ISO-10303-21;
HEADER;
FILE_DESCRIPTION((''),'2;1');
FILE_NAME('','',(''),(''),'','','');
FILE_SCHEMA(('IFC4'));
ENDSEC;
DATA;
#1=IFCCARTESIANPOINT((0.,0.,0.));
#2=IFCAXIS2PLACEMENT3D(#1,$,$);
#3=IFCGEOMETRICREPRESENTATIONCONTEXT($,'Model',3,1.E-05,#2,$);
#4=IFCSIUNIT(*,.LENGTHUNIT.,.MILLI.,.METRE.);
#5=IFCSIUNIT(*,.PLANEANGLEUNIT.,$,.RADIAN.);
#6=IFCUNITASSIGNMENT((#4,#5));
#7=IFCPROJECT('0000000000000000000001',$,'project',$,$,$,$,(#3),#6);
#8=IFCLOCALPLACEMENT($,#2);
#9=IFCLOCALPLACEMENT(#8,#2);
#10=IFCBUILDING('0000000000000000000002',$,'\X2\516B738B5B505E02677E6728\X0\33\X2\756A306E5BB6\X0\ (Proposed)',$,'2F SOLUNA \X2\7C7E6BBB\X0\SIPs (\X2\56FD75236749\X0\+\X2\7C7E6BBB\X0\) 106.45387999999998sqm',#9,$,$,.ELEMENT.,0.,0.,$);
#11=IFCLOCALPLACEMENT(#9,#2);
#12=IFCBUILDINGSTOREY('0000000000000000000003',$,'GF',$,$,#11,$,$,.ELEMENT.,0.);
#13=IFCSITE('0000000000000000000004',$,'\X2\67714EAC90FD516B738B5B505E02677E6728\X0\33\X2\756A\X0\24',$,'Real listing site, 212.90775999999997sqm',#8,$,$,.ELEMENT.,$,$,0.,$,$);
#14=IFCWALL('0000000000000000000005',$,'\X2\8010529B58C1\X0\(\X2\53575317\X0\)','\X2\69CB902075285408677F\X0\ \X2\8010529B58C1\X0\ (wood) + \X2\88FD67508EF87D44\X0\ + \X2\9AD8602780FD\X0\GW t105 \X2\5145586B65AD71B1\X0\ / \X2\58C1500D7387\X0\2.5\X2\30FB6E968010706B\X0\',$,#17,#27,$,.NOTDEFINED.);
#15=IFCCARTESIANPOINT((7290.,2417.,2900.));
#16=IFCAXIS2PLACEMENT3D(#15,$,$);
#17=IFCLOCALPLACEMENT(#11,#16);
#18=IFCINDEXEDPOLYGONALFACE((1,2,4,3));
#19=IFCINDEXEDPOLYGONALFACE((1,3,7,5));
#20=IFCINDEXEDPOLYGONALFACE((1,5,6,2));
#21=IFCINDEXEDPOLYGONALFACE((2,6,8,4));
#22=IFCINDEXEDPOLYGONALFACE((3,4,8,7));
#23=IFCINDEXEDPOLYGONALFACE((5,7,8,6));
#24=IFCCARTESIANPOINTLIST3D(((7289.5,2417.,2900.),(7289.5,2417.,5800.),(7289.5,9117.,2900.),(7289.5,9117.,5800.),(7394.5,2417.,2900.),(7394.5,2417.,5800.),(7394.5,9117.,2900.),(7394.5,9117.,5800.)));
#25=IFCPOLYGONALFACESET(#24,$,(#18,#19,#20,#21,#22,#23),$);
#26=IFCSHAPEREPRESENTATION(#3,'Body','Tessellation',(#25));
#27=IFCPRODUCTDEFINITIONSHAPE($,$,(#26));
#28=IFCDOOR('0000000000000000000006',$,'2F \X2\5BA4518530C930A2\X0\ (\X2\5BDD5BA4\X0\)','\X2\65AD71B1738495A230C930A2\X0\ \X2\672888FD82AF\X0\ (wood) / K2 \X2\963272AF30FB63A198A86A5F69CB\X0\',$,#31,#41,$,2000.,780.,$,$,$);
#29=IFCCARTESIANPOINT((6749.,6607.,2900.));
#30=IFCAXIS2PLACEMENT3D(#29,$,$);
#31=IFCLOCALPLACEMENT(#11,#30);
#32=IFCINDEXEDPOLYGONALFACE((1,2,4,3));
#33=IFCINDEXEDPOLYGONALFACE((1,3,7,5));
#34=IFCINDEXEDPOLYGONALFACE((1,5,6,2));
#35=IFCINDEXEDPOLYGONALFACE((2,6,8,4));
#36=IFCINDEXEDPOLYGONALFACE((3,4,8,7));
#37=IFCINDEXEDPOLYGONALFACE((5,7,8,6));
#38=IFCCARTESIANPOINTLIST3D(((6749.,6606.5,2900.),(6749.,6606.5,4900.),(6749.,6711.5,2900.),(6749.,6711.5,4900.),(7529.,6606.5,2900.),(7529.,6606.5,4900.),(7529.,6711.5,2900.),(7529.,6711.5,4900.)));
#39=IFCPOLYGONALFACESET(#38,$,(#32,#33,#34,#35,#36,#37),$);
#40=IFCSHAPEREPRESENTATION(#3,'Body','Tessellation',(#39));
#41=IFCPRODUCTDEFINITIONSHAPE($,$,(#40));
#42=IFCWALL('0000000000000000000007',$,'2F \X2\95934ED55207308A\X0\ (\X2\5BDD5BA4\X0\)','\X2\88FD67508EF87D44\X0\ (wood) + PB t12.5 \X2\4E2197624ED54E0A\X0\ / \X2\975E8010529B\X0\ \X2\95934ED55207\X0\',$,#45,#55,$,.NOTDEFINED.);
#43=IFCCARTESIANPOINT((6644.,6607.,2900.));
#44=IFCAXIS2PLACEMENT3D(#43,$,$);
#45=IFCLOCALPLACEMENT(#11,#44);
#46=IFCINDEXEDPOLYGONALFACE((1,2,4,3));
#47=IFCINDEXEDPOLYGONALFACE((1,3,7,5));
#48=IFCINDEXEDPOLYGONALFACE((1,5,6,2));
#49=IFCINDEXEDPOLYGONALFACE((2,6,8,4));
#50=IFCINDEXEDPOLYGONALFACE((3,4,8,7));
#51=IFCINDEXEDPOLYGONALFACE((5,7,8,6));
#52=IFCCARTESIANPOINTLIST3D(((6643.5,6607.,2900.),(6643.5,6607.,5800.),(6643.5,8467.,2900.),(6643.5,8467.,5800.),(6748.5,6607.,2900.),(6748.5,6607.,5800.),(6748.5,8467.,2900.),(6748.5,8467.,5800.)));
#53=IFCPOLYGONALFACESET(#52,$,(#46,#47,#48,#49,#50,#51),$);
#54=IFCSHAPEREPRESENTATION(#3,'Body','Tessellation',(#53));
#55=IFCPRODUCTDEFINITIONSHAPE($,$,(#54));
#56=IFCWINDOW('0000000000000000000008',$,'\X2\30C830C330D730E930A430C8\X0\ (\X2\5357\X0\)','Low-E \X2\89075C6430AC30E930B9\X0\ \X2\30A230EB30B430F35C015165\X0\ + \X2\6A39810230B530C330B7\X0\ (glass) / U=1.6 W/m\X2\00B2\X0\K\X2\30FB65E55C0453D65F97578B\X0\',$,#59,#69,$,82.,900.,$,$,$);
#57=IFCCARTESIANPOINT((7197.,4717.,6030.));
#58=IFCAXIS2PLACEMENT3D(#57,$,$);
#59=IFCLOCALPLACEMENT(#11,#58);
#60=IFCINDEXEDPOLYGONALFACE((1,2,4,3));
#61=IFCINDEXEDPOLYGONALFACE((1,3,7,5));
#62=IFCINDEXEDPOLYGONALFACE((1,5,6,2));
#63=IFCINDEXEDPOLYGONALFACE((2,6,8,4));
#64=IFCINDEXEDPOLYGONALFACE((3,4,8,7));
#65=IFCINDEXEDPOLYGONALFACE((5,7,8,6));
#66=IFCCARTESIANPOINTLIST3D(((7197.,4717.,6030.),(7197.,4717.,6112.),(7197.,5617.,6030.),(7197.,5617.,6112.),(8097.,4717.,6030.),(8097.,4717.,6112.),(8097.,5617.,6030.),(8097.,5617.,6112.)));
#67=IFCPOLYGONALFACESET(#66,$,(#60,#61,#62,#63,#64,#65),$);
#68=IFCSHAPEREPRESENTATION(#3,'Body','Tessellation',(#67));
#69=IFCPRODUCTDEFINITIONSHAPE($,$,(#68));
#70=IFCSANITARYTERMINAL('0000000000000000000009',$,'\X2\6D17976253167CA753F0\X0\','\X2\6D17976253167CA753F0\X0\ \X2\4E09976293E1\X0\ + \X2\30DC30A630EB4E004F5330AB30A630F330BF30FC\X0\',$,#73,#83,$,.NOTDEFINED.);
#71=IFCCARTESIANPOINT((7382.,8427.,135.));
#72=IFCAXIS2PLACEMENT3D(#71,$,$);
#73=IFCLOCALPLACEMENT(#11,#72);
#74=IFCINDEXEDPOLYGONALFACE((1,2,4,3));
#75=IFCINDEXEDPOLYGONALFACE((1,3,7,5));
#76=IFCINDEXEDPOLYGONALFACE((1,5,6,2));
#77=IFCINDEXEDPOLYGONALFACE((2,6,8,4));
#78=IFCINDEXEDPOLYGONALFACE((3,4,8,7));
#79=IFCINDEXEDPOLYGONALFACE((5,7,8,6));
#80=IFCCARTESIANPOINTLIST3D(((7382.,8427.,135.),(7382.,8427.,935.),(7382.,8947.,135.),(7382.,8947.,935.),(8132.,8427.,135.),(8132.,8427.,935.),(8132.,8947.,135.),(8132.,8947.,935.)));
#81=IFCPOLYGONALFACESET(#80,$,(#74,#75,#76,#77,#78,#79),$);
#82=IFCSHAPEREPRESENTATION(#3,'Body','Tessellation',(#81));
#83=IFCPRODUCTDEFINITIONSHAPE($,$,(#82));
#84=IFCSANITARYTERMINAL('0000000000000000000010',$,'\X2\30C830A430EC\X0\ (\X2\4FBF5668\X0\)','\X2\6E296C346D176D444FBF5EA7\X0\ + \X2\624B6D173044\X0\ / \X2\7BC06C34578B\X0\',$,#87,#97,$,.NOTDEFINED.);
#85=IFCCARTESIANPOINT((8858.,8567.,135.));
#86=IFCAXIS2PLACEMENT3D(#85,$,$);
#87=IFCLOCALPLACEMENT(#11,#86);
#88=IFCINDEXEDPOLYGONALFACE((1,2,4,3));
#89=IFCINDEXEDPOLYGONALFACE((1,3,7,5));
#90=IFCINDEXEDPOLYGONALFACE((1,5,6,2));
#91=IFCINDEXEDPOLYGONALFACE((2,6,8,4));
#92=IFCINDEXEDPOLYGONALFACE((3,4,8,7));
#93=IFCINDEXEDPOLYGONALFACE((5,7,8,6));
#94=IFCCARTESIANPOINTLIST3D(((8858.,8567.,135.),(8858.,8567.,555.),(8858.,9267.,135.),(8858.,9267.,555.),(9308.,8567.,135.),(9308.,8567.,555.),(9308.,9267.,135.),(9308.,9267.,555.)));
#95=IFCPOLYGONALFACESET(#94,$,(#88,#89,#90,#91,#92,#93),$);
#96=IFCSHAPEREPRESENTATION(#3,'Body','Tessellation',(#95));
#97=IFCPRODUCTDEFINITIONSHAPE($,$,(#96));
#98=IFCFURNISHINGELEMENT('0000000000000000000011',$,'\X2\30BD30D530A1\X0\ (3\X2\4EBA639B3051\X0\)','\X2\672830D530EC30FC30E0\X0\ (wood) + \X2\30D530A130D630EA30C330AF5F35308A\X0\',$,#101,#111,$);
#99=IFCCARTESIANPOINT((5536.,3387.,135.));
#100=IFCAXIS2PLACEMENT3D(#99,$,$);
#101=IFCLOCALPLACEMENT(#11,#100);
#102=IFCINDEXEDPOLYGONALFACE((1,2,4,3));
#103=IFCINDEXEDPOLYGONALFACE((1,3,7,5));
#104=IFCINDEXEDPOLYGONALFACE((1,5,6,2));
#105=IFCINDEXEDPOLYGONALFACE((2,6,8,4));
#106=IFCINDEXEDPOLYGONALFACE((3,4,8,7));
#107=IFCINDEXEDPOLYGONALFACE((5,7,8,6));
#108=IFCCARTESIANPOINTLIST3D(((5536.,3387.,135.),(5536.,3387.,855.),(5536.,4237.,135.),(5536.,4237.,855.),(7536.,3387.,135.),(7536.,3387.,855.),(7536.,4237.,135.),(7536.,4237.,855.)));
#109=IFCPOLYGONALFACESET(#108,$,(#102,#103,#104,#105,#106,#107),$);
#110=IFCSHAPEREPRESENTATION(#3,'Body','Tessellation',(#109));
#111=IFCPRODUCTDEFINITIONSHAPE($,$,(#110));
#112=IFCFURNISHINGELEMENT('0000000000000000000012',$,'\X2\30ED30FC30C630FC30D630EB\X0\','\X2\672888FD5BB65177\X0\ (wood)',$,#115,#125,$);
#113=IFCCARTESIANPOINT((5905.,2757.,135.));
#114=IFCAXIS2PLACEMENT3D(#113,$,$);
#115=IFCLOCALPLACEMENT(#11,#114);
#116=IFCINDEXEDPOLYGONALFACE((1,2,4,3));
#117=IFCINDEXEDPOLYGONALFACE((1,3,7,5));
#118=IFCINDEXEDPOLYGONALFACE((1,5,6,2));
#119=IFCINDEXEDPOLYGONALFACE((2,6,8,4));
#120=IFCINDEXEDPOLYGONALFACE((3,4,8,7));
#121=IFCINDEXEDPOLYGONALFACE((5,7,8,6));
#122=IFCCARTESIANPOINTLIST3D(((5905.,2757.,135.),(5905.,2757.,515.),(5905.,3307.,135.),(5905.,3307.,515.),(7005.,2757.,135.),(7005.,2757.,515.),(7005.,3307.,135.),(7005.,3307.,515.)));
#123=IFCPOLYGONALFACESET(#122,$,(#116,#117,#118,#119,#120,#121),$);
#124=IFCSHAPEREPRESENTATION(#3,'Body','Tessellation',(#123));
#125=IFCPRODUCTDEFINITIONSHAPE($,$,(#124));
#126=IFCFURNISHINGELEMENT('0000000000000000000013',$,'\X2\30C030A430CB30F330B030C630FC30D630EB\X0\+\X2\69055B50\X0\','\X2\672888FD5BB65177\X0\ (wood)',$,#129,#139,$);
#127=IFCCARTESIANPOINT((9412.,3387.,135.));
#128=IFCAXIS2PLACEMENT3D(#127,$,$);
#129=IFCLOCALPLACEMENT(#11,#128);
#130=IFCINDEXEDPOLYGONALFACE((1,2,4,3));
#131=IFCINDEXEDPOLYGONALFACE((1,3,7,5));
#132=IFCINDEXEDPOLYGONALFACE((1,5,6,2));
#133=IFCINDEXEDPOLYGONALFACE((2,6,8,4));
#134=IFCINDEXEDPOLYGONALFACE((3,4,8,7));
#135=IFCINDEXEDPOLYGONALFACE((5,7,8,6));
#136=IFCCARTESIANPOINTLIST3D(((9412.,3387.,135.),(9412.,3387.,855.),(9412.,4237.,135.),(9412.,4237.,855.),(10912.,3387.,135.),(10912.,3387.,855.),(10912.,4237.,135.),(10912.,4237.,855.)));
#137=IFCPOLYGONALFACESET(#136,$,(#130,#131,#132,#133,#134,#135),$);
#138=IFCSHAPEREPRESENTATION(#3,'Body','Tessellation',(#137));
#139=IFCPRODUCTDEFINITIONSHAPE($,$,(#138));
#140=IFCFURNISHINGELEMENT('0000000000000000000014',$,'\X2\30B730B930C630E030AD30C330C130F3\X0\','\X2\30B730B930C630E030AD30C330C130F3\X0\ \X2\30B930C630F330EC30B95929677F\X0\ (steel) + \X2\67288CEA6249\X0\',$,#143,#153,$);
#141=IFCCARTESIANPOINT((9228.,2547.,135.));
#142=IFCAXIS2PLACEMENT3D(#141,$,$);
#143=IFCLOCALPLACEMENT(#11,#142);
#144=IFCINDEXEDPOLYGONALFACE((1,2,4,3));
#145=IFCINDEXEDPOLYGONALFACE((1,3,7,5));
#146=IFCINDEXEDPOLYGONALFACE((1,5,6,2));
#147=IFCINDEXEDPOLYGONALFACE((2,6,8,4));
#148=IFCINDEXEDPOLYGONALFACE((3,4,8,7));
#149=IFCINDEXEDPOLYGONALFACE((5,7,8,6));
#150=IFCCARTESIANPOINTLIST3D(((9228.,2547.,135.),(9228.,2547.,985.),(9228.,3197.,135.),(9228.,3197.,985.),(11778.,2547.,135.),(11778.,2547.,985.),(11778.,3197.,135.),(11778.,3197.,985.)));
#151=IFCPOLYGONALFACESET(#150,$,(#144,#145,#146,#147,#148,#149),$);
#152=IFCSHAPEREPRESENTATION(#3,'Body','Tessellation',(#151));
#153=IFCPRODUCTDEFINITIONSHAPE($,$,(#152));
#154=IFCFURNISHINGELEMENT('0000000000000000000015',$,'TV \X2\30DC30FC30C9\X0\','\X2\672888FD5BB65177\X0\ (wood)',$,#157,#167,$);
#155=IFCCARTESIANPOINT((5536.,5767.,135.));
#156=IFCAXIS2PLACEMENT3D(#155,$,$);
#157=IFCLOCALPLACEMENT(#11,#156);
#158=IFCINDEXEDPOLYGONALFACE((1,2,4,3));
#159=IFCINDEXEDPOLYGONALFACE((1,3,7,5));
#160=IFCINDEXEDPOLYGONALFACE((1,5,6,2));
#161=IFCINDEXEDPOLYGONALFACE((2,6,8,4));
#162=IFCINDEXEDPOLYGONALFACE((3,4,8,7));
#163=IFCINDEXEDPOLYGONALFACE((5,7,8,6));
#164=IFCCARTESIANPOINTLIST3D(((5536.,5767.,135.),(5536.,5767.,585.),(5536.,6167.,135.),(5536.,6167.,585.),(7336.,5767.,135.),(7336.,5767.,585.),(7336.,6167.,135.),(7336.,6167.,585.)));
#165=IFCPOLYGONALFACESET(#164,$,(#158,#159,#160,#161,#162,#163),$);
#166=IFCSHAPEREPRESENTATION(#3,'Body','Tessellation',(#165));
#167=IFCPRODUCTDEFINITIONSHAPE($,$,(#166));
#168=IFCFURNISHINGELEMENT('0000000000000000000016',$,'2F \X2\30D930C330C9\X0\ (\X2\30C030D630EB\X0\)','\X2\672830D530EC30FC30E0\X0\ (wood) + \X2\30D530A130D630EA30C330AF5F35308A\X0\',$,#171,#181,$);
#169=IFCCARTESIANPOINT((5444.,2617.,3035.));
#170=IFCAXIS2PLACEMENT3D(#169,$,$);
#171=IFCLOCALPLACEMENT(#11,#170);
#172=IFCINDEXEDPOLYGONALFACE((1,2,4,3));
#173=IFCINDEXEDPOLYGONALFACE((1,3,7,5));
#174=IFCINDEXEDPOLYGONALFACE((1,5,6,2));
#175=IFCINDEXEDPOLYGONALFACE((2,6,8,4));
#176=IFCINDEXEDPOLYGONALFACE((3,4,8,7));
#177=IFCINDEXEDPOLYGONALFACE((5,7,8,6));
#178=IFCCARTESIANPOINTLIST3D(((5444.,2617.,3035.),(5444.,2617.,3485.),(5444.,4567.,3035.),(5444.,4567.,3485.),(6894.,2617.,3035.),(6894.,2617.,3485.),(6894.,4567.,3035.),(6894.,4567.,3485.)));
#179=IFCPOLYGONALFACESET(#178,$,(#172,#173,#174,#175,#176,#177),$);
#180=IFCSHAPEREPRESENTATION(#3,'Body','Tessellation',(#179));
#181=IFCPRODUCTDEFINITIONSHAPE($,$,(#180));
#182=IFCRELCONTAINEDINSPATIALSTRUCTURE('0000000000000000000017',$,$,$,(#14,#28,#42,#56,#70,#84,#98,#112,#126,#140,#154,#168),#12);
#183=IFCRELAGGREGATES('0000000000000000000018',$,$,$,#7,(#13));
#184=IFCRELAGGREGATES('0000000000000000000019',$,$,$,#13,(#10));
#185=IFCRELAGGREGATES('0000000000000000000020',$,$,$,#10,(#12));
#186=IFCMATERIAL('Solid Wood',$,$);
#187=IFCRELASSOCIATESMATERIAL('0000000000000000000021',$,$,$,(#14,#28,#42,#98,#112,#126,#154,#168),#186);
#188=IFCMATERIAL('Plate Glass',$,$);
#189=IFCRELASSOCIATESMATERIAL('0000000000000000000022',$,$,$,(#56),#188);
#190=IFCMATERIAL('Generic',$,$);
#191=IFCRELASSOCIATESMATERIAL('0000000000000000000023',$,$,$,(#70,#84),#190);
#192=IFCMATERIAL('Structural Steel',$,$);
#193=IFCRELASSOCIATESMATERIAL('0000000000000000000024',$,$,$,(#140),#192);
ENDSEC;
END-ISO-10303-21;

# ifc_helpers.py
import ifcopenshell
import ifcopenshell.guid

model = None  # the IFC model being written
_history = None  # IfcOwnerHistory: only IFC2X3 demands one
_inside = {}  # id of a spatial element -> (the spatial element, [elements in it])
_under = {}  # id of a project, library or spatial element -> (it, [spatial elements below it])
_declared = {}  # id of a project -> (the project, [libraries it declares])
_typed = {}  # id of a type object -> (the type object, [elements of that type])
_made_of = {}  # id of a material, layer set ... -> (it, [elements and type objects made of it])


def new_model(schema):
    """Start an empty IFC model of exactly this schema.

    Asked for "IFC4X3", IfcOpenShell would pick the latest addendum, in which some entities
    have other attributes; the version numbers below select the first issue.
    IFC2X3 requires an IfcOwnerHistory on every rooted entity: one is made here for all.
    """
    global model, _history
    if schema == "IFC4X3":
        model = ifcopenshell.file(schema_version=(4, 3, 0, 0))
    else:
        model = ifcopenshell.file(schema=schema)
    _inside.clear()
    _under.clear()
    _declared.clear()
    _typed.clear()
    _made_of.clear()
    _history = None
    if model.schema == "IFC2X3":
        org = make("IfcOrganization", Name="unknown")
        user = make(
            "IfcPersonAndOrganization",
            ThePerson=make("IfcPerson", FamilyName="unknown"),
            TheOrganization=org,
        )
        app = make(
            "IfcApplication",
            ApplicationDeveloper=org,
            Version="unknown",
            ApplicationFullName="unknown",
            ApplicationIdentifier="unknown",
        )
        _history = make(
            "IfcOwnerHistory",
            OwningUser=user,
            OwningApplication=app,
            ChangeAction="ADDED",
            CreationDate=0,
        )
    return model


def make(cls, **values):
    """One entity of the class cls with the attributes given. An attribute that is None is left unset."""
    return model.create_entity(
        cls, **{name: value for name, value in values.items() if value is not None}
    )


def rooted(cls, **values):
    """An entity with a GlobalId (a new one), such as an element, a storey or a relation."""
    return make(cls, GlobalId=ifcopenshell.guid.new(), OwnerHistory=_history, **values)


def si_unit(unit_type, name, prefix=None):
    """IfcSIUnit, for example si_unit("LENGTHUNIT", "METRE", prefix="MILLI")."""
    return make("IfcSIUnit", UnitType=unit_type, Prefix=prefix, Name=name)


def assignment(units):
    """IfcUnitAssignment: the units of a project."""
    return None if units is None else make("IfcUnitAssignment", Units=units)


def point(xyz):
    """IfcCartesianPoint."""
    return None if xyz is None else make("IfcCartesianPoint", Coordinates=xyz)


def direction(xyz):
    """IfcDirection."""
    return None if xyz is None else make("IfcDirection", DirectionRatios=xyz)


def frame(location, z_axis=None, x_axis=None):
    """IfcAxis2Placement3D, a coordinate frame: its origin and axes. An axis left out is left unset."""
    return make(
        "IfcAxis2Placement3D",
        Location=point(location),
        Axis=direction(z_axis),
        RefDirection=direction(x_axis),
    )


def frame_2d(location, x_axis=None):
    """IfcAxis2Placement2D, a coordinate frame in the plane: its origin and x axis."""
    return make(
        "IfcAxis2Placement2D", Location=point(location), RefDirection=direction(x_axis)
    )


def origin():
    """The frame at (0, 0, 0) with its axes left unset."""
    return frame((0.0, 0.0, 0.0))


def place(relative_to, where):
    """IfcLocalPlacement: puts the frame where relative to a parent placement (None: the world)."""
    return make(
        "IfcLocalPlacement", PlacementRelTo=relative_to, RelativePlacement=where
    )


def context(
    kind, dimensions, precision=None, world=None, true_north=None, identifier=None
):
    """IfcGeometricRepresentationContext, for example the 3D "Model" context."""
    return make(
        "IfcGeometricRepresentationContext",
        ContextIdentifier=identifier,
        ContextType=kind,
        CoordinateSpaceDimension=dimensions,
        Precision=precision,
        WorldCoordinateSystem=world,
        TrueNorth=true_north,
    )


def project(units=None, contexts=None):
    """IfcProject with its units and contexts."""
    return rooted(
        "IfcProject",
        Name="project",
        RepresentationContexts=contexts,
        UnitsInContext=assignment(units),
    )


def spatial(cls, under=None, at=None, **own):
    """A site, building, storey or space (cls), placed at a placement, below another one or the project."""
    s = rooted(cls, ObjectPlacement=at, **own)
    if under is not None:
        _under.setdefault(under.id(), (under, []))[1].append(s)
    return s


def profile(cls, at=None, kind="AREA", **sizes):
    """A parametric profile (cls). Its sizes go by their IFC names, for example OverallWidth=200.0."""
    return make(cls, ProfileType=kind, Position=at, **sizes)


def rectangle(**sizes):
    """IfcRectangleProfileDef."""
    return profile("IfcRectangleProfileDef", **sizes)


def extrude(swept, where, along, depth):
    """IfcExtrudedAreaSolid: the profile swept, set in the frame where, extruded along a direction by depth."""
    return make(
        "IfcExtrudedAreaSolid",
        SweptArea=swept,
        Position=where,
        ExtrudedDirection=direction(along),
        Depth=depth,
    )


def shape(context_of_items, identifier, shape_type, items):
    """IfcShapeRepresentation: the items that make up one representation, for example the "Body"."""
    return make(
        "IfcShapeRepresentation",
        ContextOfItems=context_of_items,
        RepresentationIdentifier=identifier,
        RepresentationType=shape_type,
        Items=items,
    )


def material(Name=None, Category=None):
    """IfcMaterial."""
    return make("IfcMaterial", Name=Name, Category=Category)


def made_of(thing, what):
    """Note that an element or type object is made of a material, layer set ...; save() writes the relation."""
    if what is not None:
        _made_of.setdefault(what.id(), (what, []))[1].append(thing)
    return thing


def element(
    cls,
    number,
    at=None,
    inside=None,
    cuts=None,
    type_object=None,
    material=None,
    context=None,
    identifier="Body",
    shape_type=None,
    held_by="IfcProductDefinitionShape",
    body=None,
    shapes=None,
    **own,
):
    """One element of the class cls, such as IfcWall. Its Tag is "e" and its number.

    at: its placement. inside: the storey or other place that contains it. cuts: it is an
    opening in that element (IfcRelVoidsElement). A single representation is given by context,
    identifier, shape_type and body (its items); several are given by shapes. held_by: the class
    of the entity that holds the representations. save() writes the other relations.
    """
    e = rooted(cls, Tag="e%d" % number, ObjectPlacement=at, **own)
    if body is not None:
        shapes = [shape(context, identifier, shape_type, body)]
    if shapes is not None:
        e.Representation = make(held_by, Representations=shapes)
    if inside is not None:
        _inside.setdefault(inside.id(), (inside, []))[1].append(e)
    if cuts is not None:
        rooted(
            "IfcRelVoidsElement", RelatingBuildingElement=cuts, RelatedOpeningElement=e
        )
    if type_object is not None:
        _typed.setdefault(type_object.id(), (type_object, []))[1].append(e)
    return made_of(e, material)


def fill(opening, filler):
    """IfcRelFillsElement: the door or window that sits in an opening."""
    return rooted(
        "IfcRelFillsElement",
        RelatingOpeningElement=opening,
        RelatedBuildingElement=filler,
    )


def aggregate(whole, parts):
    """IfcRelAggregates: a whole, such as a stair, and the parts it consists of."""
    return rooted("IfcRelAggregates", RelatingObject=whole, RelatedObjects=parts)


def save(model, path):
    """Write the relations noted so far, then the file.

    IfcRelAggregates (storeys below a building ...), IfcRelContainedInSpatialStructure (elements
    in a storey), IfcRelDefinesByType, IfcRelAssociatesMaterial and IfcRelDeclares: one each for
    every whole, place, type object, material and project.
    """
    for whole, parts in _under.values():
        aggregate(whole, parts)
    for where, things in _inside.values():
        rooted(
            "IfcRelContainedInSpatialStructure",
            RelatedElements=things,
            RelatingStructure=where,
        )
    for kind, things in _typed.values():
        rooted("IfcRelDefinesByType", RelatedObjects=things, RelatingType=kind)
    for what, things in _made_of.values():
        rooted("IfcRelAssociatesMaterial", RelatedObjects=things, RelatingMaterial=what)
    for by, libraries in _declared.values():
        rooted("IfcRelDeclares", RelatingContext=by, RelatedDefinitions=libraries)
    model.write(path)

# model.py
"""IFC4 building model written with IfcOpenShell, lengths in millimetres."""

from ifc_helpers import new_model, si_unit, frame, frame_2d, origin, place, context, project, spatial, rectangle, extrude, material, element, fill, save


model = new_model("IFC4")

# Units and contexts
model_context = context("Model", 3, precision=1e-05, world=origin())
ifc_project = project(units=[si_unit("LENGTHUNIT", "METRE", prefix="MILLI"), si_unit("PLANEANGLEUNIT", "RADIAN")], contexts=[model_context])

# Site, building, storey
site_placement = place(None, origin())
site = spatial("IfcSite", under=ifc_project, at=site_placement, Name="東京都八王子市松木33番24", ObjectType="Real listing site, 212.90775999999997sqm", CompositionType="ELEMENT", RefElevation=0.0)
building_placement = place(site_placement, origin())
building = spatial("IfcBuilding", under=site, at=building_placement, Name="八王子市松木33番の家 (Proposed)", ObjectType="2F SOLUNA 籾殻SIPs (国産杉+籾殻) 106.45387999999998sqm", CompositionType="ELEMENT", ElevationOfRefHeight=0.0, ElevationOfTerrain=0.0)
storey_placement = place(building_placement, origin())
storey = spatial("IfcBuildingStorey", under=building, at=storey_placement, Name="GF", CompositionType="ELEMENT", Elevation=0.0)

# Shared definitions
ifc_material_1 = material(Name="Solid Wood")

# Wall, opening, door
wall_1_placement = place(storey_placement, frame((7290.0, 2417.0, 2900.0)))
wall_1 = element("IfcWall", 1, at=wall_1_placement, inside=storey, material=ifc_material_1, Name="耐力壁(南北)", Description="構造用合板 耐力壁 (wood) + 製材軸組 + 高性能GW t105 充填断熱 / 壁倍率2.5・準耐火", PredefinedType="NOTDEFINED", context=model_context, shape_type="SweptSolid", body=[
    extrude(rectangle(XDim=105.0, YDim=6700.0, at=frame_2d((52.0, 3350.0))), frame((7290.0, 2417.0, 2900.0)), (0.0, 0.0, 1.0), 2900.0),
])
opening_1_placement = place(storey_placement, frame((6749.0, 6607.0, 2900.0)))
opening_1 = element("IfcOpeningElement", 2, at=opening_1_placement, cuts=wall_1, PredefinedType="NOTDEFINED", context=model_context, shape_type="SweptSolid", body=[
    extrude(rectangle(XDim=780.0, YDim=105.0, at=frame_2d((390.0, 52.0))), frame((6749.0, 6607.0, 2900.0)), (0.0, 0.0, 1.0), 2000.0),
])
door_1_placement = place(storey_placement, frame((6749.0, 6607.0, 2900.0)))
door_1 = element("IfcDoor", 3, at=door_1_placement, inside=storey, material=ifc_material_1, Name="2F 室内ドア (寝室)", Description="断熱玄関ドア 木製芯 (wood) / K2 防犯・採風機構", OverallHeight=2000.0, OverallWidth=780.0, context=model_context, shape_type="SweptSolid", body=[
    extrude(rectangle(XDim=780.0, YDim=105.0, at=frame_2d((390.0, 52.0))), frame((6749.0, 6607.0, 2900.0)), (0.0, 0.0, 1.0), 2000.0),
])
fill(opening_1, door_1)

# Wall
wall_2_placement = place(storey_placement, frame((6644.0, 6607.0, 2900.0)))
element("IfcWall", 4, at=wall_2_placement, inside=storey, material=ifc_material_1, Name="2F 間仕切り (寝室)", Description="製材軸組 (wood) + PB t12.5 両面仕上 / 非耐力 間仕切", PredefinedType="NOTDEFINED", context=model_context, shape_type="SweptSolid", body=[
    extrude(rectangle(XDim=105.0, YDim=1860.0, at=frame_2d((52.0, 930.0))), frame((6644.0, 6607.0, 2900.0)), (0.0, 0.0, 1.0), 2900.0),
])

# Window
ifc_material_2 = material(Name="Plate Glass")
window_placement = place(storey_placement, frame((7197.0, 4717.0, 6030.0)))
element("IfcWindow", 5, at=window_placement, inside=storey, material=ifc_material_2, Name="トップライト (南)", Description="Low-E 複層ガラス アルゴン封入 + 樹脂サッシ (glass) / U=1.6 W/m²K・日射取得型", OverallHeight=82.0, OverallWidth=900.0, context=model_context, shape_type="SweptSolid", body=[
    extrude(rectangle(XDim=900.0, YDim=900.0, at=frame_2d((450.0, 450.0))), frame((7197.0, 4717.0, 6030.0)), (0.0, 0.0, 1.0), 82.0),
])

# Sanitary terminals
ifc_material_3 = material(Name="Generic")
sanitary_terminal_1_placement = place(storey_placement, frame((7382.0, 8427.0, 135.0)))
element("IfcSanitaryTerminal", 6, at=sanitary_terminal_1_placement, inside=storey, material=ifc_material_3, Name="洗面化粧台", Description="洗面化粧台 三面鏡 + ボウル一体カウンター", PredefinedType="NOTDEFINED", context=model_context, shape_type="SweptSolid", body=[
    extrude(rectangle(XDim=750.0, YDim=520.0, at=frame_2d((375.0, 260.0))), frame((7382.0, 8427.0, 135.0)), (0.0, 0.0, 1.0), 800.0),
])
sanitary_terminal_2_placement = place(storey_placement, frame((8858.0, 8567.0, 135.0)))
element("IfcSanitaryTerminal", 7, at=sanitary_terminal_2_placement, inside=storey, material=ifc_material_3, Name="トイレ (便器)", Description="温水洗浄便座 + 手洗い / 節水型", PredefinedType="NOTDEFINED", context=model_context, shape_type="SweptSolid", body=[
    extrude(rectangle(XDim=450.0, YDim=700.0, at=frame_2d((225.0, 350.0))), frame((8858.0, 8567.0, 135.0)), (0.0, 0.0, 1.0), 420.0),
])

# Furnishing elements
furnishing_1_placement = place(storey_placement, frame((5536.0, 3387.0, 135.0)))
element("IfcFurnishingElement", 8, at=furnishing_1_placement, inside=storey, material=ifc_material_1, Name="ソファ (3人掛け)", Description="木フレーム (wood) + ファブリック張り", context=model_context, shape_type="SweptSolid", body=[
    extrude(rectangle(XDim=2000.0, YDim=850.0, at=frame_2d((1000.0, 425.0))), frame((5536.0, 3387.0, 135.0)), (0.0, 0.0, 1.0), 720.0),
])
furnishing_2_placement = place(storey_placement, frame((5905.0, 2757.0, 135.0)))
element("IfcFurnishingElement", 9, at=furnishing_2_placement, inside=storey, material=ifc_material_1, Name="ローテーブル", Description="木製家具 (wood)", context=model_context, shape_type="SweptSolid", body=[
    extrude(rectangle(XDim=1100.0, YDim=550.0, at=frame_2d((550.0, 275.0))), frame((5905.0, 2757.0, 135.0)), (0.0, 0.0, 1.0), 380.0),
])
furnishing_3_placement = place(storey_placement, frame((9412.0, 3387.0, 135.0)))
element("IfcFurnishingElement", 10, at=furnishing_3_placement, inside=storey, material=ifc_material_1, Name="ダイニングテーブル+椅子", Description="木製家具 (wood)", context=model_context, shape_type="SweptSolid", body=[
    extrude(rectangle(XDim=1500.0, YDim=850.0, at=frame_2d((750.0, 425.0))), frame((9412.0, 3387.0, 135.0)), (0.0, 0.0, 1.0), 720.0),
])
ifc_material_4 = material(Name="Structural Steel")
furnishing_4_placement = place(storey_placement, frame((9228.0, 2547.0, 135.0)))
element("IfcFurnishingElement", 11, at=furnishing_4_placement, inside=storey, material=ifc_material_4, Name="システムキッチン", Description="システムキッチン ステンレス天板 (steel) + 木質扉", context=model_context, shape_type="SweptSolid", body=[
    extrude(rectangle(XDim=2550.0, YDim=650.0, at=frame_2d((1275.0, 325.0))), frame((9228.0, 2547.0, 135.0)), (0.0, 0.0, 1.0), 850.0),
])
furnishing_5_placement = place(storey_placement, frame((5536.0, 5767.0, 135.0)))
element("IfcFurnishingElement", 12, at=furnishing_5_placement, inside=storey, material=ifc_material_1, Name="TV ボード", Description="木製家具 (wood)", context=model_context, shape_type="SweptSolid", body=[
    extrude(rectangle(XDim=1800.0, YDim=400.0, at=frame_2d((900.0, 200.0))), frame((5536.0, 5767.0, 135.0)), (0.0, 0.0, 1.0), 450.0),
])
furnishing_6_placement = place(storey_placement, frame((5444.0, 2617.0, 3035.0)))
element("IfcFurnishingElement", 13, at=furnishing_6_placement, inside=storey, material=ifc_material_1, Name="2F ベッド (ダブル)", Description="木フレーム (wood) + ファブリック張り", context=model_context, shape_type="SweptSolid", body=[
    extrude(rectangle(XDim=1450.0, YDim=1950.0, at=frame_2d((725.0, 975.0))), frame((5444.0, 2617.0, 3035.0)), (0.0, 0.0, 1.0), 450.0),
])

save(model, "model.ifc")
